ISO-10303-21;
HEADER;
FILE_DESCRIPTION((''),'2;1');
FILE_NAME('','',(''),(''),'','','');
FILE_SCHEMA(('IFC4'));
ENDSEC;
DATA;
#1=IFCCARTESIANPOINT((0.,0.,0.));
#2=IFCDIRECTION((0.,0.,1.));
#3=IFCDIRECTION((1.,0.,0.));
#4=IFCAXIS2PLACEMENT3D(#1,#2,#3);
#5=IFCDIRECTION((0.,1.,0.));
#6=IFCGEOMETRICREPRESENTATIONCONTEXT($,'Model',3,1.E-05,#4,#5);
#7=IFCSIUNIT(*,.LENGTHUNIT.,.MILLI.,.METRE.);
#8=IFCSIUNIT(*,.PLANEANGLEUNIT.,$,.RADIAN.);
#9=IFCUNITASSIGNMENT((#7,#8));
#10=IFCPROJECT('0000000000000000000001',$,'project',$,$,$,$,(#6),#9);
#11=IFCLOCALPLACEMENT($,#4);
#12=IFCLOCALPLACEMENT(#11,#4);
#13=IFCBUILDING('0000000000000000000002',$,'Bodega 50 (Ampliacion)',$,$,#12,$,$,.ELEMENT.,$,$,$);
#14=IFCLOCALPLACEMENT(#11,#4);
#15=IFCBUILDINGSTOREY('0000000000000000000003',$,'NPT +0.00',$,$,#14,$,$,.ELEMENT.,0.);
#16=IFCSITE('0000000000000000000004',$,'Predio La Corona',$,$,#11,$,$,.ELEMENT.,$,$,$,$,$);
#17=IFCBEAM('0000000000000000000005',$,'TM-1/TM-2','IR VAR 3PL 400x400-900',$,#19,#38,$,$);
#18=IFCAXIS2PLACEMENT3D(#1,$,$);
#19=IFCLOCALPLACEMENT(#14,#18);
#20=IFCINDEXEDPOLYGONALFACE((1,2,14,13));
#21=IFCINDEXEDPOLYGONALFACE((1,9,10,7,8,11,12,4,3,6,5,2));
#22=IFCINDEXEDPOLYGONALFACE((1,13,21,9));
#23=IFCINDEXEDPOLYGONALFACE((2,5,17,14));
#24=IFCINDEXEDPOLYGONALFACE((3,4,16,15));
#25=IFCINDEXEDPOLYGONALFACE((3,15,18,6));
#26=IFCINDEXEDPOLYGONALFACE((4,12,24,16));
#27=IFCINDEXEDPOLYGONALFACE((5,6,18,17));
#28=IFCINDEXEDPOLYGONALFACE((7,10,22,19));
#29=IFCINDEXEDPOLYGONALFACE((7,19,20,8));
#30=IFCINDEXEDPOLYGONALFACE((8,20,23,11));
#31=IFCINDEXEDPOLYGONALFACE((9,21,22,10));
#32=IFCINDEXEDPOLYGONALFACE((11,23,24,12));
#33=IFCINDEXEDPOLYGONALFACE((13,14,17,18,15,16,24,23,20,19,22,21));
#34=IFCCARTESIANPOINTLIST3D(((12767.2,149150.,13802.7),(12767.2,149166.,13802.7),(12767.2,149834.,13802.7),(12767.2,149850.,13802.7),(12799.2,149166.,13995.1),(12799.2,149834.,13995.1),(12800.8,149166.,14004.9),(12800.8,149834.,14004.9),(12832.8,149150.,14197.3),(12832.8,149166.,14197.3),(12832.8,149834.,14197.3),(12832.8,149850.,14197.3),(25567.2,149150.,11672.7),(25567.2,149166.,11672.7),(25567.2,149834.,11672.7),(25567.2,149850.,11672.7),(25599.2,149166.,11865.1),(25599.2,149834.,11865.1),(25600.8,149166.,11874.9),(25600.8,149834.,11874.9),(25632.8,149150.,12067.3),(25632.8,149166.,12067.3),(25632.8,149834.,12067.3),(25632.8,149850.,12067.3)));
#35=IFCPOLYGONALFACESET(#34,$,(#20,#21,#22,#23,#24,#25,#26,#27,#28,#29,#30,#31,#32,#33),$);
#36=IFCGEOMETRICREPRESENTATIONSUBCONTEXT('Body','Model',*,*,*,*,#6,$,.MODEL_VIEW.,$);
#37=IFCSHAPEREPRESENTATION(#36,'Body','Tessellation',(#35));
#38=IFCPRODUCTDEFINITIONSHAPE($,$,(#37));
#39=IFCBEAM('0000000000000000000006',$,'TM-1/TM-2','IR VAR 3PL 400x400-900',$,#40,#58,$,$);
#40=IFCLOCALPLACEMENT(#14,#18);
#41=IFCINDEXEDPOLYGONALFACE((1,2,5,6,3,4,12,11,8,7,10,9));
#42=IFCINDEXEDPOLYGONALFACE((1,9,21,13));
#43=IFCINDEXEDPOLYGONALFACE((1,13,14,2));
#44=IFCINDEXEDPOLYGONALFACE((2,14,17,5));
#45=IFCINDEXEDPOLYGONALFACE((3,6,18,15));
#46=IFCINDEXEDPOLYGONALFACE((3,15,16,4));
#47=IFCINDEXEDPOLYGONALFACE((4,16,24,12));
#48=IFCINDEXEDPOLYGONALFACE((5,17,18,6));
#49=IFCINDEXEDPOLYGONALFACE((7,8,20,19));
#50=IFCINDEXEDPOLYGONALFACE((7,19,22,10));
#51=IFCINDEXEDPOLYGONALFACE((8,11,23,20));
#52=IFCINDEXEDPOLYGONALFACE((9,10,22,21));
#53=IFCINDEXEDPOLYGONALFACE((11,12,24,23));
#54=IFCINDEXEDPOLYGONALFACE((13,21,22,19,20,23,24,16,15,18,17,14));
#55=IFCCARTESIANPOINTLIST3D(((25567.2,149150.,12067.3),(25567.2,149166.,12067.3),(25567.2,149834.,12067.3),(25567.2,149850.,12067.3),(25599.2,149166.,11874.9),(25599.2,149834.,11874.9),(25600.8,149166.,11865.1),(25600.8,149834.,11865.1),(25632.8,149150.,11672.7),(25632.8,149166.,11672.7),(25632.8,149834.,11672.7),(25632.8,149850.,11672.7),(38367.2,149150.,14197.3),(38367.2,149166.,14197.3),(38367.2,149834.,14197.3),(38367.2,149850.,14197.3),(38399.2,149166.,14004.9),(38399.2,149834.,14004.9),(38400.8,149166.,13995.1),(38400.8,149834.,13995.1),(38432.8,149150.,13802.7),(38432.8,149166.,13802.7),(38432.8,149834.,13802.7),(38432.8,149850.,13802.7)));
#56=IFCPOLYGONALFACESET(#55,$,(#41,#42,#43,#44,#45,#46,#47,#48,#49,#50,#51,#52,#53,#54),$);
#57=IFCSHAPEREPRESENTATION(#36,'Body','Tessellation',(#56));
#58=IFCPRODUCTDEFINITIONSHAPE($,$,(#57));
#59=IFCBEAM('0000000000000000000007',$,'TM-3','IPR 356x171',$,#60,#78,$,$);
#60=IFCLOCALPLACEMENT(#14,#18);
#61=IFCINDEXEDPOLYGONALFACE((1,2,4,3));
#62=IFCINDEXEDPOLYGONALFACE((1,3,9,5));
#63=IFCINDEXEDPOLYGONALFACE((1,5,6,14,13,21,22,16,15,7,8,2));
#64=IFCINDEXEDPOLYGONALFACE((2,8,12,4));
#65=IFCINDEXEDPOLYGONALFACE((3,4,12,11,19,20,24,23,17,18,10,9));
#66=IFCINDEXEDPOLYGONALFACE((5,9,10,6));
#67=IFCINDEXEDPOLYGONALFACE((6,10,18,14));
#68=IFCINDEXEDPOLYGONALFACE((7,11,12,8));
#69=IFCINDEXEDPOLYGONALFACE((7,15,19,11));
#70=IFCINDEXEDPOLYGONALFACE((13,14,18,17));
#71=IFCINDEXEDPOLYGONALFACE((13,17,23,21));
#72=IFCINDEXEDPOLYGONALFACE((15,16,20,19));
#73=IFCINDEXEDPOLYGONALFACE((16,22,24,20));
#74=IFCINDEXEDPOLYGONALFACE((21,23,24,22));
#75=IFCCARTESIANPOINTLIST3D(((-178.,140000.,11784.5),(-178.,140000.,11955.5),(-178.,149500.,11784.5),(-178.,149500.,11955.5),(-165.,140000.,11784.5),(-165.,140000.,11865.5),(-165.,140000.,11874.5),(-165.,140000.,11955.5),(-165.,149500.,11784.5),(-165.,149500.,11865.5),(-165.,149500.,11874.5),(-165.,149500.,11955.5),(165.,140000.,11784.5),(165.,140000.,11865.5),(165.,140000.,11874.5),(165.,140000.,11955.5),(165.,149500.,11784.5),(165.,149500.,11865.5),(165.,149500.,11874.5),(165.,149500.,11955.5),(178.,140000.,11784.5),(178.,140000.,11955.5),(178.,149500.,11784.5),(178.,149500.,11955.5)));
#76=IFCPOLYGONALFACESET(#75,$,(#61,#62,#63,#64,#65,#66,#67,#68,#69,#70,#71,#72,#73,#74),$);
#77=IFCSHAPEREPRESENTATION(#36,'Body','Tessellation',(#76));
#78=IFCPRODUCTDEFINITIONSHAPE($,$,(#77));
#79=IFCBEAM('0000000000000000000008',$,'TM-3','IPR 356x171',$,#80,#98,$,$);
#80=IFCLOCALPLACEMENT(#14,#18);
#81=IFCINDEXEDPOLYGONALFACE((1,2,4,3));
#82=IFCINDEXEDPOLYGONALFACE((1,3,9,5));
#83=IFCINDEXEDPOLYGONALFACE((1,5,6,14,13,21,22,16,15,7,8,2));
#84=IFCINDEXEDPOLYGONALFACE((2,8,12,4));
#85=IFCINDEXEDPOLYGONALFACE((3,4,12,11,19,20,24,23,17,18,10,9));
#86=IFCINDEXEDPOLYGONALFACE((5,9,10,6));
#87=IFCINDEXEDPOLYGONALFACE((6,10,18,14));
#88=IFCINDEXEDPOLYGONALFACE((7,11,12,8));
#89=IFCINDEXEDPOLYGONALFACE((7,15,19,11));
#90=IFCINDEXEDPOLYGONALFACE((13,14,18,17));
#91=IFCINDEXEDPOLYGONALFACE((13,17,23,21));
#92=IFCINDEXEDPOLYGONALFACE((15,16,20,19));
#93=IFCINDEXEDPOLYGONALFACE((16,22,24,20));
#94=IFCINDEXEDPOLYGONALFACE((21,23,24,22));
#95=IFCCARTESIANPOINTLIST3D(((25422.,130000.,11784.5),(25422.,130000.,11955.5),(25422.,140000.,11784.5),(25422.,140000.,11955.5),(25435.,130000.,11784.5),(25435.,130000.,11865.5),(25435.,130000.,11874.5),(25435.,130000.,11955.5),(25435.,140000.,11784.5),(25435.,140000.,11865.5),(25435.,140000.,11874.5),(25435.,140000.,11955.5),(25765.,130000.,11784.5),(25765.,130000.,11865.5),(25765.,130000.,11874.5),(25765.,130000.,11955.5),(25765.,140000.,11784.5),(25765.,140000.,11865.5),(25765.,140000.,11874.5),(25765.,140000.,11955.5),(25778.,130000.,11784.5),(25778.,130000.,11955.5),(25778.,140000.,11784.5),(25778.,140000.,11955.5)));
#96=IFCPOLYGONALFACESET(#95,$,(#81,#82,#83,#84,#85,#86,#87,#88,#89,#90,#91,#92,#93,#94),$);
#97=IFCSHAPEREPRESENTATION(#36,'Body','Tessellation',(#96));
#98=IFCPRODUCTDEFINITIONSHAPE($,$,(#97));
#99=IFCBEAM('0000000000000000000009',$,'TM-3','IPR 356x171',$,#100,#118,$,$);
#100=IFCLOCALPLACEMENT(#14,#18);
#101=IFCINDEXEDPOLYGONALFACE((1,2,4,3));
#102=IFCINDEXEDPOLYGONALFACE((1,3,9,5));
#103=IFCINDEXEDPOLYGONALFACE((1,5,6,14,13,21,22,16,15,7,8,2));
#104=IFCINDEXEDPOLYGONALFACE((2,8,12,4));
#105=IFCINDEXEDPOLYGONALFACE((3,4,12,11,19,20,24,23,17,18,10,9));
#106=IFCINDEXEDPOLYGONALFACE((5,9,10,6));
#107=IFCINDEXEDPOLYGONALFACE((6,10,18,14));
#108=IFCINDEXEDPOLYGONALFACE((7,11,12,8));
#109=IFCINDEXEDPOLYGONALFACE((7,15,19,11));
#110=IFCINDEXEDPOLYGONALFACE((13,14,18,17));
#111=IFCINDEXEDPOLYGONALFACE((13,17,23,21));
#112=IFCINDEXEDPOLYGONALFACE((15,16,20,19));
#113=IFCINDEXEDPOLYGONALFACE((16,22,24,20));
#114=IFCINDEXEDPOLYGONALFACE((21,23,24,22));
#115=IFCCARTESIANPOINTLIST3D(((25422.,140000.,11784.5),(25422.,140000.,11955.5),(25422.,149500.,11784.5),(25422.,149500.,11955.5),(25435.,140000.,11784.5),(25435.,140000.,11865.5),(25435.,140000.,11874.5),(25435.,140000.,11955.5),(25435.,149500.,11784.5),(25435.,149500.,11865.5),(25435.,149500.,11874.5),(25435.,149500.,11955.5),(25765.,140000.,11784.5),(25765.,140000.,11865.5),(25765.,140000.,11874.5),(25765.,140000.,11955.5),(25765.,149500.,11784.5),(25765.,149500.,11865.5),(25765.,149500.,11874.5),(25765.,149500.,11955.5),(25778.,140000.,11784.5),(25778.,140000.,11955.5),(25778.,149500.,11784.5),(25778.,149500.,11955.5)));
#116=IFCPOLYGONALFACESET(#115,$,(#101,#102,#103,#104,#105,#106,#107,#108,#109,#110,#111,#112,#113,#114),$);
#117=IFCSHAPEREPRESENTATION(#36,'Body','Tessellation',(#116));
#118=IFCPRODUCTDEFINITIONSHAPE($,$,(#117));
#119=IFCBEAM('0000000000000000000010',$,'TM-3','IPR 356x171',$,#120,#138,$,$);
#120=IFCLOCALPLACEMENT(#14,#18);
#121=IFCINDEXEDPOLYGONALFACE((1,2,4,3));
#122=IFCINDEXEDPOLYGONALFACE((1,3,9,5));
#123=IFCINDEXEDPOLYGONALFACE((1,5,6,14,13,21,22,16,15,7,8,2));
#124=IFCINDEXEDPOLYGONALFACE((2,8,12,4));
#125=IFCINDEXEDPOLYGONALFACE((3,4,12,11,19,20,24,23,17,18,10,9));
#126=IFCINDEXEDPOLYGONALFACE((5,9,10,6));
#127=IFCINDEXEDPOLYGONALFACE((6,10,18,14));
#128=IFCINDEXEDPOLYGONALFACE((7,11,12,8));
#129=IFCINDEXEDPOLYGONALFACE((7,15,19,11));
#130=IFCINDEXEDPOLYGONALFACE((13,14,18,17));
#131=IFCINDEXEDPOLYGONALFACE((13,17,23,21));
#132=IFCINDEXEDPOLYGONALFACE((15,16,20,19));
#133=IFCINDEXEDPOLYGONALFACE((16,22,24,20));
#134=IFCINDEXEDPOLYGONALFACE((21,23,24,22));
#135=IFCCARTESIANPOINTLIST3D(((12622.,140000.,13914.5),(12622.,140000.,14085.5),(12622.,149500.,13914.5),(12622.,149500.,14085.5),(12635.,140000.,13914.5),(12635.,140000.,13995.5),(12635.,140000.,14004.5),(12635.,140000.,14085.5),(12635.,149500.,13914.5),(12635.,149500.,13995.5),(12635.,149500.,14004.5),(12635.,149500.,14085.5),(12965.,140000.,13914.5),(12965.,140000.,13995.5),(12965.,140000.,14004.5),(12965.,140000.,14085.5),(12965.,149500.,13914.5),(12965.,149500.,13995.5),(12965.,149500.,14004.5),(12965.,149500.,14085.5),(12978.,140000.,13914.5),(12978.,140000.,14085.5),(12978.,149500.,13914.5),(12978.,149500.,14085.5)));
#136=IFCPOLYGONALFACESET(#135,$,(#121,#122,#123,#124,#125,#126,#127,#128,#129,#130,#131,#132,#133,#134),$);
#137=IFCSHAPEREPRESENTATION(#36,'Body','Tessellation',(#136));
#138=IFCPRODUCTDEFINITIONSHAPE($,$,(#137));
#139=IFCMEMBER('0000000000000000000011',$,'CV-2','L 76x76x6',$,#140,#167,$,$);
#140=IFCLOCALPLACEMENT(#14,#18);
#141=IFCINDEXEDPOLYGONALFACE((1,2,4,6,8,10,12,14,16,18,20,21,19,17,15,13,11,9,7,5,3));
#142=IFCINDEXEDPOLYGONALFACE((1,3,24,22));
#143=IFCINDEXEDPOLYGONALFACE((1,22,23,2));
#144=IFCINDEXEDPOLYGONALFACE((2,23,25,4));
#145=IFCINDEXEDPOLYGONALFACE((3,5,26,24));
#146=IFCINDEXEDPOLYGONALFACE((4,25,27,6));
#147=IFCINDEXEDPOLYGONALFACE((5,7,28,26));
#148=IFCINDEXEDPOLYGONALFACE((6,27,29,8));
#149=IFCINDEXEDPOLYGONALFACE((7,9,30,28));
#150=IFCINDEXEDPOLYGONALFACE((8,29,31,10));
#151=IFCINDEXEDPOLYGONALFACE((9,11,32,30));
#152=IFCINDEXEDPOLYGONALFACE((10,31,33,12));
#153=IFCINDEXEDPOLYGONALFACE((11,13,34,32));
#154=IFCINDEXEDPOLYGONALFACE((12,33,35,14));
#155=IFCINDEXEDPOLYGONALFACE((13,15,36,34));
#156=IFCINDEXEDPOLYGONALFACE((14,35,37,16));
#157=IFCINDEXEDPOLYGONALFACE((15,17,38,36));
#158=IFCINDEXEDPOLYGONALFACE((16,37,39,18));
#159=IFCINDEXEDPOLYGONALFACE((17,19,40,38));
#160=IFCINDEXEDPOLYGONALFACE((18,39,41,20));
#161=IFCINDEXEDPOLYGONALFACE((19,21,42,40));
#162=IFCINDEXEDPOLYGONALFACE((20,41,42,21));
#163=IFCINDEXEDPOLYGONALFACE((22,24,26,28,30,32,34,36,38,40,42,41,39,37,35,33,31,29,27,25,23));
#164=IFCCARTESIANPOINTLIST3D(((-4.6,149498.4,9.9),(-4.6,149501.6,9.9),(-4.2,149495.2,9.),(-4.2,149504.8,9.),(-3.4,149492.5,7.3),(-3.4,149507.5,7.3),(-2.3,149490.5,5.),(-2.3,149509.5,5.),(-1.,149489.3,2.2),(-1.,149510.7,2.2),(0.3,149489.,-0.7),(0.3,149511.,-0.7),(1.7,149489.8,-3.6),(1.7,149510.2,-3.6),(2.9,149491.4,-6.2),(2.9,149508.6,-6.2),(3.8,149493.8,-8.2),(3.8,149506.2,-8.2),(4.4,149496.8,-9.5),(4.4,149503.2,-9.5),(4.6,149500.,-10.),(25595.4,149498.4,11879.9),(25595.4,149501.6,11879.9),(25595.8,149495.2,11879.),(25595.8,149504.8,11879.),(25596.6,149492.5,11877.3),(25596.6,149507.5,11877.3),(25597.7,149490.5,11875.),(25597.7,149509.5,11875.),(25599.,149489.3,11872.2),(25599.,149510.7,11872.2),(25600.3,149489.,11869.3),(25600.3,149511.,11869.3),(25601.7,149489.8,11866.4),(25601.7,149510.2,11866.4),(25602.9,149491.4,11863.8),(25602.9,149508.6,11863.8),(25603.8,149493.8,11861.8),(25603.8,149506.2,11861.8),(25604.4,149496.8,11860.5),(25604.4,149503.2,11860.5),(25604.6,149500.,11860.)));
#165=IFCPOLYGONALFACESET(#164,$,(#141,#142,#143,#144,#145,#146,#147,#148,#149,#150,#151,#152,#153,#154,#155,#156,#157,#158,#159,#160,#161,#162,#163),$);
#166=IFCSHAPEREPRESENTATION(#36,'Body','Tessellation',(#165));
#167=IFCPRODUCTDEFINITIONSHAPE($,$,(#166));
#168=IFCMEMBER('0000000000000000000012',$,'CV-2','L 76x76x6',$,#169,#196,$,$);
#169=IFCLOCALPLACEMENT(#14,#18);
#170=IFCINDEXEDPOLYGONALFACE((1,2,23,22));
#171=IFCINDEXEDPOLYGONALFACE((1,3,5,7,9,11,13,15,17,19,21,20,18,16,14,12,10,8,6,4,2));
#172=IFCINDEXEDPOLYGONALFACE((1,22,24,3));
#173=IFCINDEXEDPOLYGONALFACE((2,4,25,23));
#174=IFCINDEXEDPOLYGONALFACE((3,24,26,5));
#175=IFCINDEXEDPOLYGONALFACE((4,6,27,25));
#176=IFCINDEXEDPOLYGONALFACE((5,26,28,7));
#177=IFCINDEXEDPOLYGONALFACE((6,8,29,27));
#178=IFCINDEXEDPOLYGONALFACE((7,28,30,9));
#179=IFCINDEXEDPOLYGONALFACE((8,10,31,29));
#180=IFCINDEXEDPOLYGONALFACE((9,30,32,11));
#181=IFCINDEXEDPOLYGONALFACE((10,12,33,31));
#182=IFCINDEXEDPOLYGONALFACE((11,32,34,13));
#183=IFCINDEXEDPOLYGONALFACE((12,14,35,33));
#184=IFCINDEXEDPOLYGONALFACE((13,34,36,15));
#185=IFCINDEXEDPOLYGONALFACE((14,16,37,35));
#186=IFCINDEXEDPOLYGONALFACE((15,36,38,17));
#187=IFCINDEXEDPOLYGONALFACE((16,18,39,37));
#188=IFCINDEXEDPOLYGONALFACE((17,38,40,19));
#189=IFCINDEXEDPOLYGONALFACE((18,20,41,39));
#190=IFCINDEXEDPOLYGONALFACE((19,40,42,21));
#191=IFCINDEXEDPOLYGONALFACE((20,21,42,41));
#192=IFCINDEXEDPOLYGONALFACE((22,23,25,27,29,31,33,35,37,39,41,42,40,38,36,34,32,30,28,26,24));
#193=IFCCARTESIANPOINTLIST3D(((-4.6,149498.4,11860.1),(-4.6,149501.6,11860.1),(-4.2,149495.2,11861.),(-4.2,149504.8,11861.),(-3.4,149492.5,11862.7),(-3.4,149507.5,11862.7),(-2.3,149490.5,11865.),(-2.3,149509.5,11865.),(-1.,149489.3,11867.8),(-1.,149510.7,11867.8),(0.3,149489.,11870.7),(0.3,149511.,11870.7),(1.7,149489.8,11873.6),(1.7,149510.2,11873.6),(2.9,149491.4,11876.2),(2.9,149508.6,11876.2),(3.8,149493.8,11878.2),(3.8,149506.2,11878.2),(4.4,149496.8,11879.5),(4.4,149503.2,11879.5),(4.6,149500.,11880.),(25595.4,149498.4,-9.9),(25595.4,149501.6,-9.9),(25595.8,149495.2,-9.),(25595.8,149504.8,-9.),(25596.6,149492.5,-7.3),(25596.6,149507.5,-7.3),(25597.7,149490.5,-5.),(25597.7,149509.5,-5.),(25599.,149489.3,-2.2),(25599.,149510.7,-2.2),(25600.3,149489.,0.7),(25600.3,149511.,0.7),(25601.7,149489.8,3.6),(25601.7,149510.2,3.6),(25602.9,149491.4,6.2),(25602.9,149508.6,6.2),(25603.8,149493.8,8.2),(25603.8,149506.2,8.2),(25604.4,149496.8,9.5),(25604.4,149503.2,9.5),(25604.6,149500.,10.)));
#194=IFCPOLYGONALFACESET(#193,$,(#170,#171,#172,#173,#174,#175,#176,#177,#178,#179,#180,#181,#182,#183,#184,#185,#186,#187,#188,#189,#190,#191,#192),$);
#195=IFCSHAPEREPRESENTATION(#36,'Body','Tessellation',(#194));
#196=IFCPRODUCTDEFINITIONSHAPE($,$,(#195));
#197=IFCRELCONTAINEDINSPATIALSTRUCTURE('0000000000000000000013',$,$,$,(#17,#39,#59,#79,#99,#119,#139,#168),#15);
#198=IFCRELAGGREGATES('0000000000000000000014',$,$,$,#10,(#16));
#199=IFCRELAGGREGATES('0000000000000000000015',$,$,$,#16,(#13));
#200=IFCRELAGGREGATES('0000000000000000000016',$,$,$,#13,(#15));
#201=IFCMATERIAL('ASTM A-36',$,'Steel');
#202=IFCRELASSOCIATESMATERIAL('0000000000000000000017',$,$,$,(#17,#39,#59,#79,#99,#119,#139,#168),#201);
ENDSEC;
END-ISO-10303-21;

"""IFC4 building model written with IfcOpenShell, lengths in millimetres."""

from ifc_helpers import new_model, si_unit, direction, frame, origin_with_axes, origin_2d, place, context, subcontext, project, spatial, circle, i_section, extrude, material, element, save


model = new_model("IFC4")

# Units and contexts
model_context = context("Model", 3, precision=1e-05, world=origin_with_axes(), true_north=direction((0.0, 1.0, 0.0)))
body_context = subcontext(model_context, "Body", "Model", "MODEL_VIEW")
ifc_project = project(units=[si_unit("LENGTHUNIT", "METRE", prefix="MILLI"), si_unit("PLANEANGLEUNIT", "RADIAN")], contexts=[model_context])

# Site, building, storey
site_placement = place(None, origin_with_axes())
site = spatial("IfcSite", under=ifc_project, at=site_placement, Name="Predio La Corona", CompositionType="ELEMENT")
building_placement = place(site_placement, origin_with_axes())
building = spatial("IfcBuilding", under=site, at=building_placement, Name="Bodega 50 (Ampliacion)", CompositionType="ELEMENT")
storey_placement = place(site_placement, origin_with_axes())
storey = spatial("IfcBuildingStorey", under=building, at=storey_placement, Name="NPT +0.00", CompositionType="ELEMENT", Elevation=0.0)

# Shared definitions
ifc_material = material(Name="ASTM A-36", Category="Steel")

# Beams
for number, where, z_axis, x_axis, name in (
    (1, (12800.0, 149500.0, 14000.0), (0.986436, 0.0, -0.164149), (-0.164149, 0.0, -0.986436), "TM-1/TM-2"),
    (2, (25600.0, 149500.0, 11870.0), (0.986436, 0.0, 0.164149), (0.164149, 0.0, -0.986436), "TM-1/TM-2"),
):
    element("IfcBeam", number, at=place(storey_placement, frame(where, z_axis=z_axis, x_axis=x_axis)), inside=storey, material=ifc_material, Name=name, Description="IR VAR 3PL 400x400-900", context=body_context, shape_type="SweptSolid", body=[
        extrude(i_section(OverallWidth=400.0, OverallDepth=700.0, WebThickness=10.0, FlangeThickness=16.0, at=origin_2d()), origin_with_axes(), (0.0, 0.0, 1.0), 12976.0),
    ])
beam_1_placement = place(storey_placement, frame((0.0, 140000.0, 11870.0), z_axis=(0.0, 1.0, 0.0), x_axis=(0.0, 0.0, 1.0)))
element("IfcBeam", 3, at=beam_1_placement, inside=storey, material=ifc_material, Name="TM-3", Description="IPR 356x171", context=body_context, shape_type="SweptSolid", body=[
    extrude(i_section(OverallWidth=171.0, OverallDepth=356.0, WebThickness=9.0, FlangeThickness=13.0, at=origin_2d()), origin_with_axes(), (0.0, 0.0, 1.0), 9500.0),
])
beam_2_placement = place(storey_placement, frame((25600.0, 130000.0, 11870.0), z_axis=(0.0, 1.0, 0.0), x_axis=(0.0, 0.0, 1.0)))
element("IfcBeam", 4, at=beam_2_placement, inside=storey, material=ifc_material, Name="TM-3", Description="IPR 356x171", context=body_context, shape_type="SweptSolid", body=[
    extrude(i_section(OverallWidth=171.0, OverallDepth=356.0, WebThickness=9.0, FlangeThickness=13.0, at=origin_2d()), origin_with_axes(), (0.0, 0.0, 1.0), 10000.0),
])
for number, where, z_axis, x_axis, name in (
    (5, (25600.0, 140000.0, 11870.0), (0.0, 1.0, 0.0), (0.0, 0.0, 1.0), "TM-3"),
    (6, (12800.0, 140000.0, 14000.0), (0.0, 1.0, 0.0), (0.0, 0.0, 1.0), "TM-3"),
):
    element("IfcBeam", number, at=place(storey_placement, frame(where, z_axis=z_axis, x_axis=x_axis)), inside=storey, material=ifc_material, Name=name, Description="IPR 356x171", context=body_context, shape_type="SweptSolid", body=[
        extrude(i_section(OverallWidth=171.0, OverallDepth=356.0, WebThickness=9.0, FlangeThickness=13.0, at=origin_2d()), origin_with_axes(), (0.0, 0.0, 1.0), 9500.0),
    ])

# Members
for number, where, z_axis, x_axis, name in (
    (7, (0.0, 149500.0, 0.0), (0.907222, 0.0, 0.420653), (0.420653, 0.0, -0.907222), "CV-2"),
    (8, (25600.0, 149500.0, 0.0), (-0.907222, 0.0, 0.420653), (0.420653, 0.0, 0.907222), "CV-2"),
):
    element("IfcMember", number, at=place(storey_placement, frame(where, z_axis=z_axis, x_axis=x_axis)), inside=storey, material=ifc_material, Name=name, Description="L 76x76x6", context=body_context, shape_type="SweptSolid", body=[
        extrude(circle(Radius=11.0, at=origin_2d()), origin_with_axes(), (0.0, 0.0, 1.0), 28218.0),
    ])

save(model, "model.ifc")
